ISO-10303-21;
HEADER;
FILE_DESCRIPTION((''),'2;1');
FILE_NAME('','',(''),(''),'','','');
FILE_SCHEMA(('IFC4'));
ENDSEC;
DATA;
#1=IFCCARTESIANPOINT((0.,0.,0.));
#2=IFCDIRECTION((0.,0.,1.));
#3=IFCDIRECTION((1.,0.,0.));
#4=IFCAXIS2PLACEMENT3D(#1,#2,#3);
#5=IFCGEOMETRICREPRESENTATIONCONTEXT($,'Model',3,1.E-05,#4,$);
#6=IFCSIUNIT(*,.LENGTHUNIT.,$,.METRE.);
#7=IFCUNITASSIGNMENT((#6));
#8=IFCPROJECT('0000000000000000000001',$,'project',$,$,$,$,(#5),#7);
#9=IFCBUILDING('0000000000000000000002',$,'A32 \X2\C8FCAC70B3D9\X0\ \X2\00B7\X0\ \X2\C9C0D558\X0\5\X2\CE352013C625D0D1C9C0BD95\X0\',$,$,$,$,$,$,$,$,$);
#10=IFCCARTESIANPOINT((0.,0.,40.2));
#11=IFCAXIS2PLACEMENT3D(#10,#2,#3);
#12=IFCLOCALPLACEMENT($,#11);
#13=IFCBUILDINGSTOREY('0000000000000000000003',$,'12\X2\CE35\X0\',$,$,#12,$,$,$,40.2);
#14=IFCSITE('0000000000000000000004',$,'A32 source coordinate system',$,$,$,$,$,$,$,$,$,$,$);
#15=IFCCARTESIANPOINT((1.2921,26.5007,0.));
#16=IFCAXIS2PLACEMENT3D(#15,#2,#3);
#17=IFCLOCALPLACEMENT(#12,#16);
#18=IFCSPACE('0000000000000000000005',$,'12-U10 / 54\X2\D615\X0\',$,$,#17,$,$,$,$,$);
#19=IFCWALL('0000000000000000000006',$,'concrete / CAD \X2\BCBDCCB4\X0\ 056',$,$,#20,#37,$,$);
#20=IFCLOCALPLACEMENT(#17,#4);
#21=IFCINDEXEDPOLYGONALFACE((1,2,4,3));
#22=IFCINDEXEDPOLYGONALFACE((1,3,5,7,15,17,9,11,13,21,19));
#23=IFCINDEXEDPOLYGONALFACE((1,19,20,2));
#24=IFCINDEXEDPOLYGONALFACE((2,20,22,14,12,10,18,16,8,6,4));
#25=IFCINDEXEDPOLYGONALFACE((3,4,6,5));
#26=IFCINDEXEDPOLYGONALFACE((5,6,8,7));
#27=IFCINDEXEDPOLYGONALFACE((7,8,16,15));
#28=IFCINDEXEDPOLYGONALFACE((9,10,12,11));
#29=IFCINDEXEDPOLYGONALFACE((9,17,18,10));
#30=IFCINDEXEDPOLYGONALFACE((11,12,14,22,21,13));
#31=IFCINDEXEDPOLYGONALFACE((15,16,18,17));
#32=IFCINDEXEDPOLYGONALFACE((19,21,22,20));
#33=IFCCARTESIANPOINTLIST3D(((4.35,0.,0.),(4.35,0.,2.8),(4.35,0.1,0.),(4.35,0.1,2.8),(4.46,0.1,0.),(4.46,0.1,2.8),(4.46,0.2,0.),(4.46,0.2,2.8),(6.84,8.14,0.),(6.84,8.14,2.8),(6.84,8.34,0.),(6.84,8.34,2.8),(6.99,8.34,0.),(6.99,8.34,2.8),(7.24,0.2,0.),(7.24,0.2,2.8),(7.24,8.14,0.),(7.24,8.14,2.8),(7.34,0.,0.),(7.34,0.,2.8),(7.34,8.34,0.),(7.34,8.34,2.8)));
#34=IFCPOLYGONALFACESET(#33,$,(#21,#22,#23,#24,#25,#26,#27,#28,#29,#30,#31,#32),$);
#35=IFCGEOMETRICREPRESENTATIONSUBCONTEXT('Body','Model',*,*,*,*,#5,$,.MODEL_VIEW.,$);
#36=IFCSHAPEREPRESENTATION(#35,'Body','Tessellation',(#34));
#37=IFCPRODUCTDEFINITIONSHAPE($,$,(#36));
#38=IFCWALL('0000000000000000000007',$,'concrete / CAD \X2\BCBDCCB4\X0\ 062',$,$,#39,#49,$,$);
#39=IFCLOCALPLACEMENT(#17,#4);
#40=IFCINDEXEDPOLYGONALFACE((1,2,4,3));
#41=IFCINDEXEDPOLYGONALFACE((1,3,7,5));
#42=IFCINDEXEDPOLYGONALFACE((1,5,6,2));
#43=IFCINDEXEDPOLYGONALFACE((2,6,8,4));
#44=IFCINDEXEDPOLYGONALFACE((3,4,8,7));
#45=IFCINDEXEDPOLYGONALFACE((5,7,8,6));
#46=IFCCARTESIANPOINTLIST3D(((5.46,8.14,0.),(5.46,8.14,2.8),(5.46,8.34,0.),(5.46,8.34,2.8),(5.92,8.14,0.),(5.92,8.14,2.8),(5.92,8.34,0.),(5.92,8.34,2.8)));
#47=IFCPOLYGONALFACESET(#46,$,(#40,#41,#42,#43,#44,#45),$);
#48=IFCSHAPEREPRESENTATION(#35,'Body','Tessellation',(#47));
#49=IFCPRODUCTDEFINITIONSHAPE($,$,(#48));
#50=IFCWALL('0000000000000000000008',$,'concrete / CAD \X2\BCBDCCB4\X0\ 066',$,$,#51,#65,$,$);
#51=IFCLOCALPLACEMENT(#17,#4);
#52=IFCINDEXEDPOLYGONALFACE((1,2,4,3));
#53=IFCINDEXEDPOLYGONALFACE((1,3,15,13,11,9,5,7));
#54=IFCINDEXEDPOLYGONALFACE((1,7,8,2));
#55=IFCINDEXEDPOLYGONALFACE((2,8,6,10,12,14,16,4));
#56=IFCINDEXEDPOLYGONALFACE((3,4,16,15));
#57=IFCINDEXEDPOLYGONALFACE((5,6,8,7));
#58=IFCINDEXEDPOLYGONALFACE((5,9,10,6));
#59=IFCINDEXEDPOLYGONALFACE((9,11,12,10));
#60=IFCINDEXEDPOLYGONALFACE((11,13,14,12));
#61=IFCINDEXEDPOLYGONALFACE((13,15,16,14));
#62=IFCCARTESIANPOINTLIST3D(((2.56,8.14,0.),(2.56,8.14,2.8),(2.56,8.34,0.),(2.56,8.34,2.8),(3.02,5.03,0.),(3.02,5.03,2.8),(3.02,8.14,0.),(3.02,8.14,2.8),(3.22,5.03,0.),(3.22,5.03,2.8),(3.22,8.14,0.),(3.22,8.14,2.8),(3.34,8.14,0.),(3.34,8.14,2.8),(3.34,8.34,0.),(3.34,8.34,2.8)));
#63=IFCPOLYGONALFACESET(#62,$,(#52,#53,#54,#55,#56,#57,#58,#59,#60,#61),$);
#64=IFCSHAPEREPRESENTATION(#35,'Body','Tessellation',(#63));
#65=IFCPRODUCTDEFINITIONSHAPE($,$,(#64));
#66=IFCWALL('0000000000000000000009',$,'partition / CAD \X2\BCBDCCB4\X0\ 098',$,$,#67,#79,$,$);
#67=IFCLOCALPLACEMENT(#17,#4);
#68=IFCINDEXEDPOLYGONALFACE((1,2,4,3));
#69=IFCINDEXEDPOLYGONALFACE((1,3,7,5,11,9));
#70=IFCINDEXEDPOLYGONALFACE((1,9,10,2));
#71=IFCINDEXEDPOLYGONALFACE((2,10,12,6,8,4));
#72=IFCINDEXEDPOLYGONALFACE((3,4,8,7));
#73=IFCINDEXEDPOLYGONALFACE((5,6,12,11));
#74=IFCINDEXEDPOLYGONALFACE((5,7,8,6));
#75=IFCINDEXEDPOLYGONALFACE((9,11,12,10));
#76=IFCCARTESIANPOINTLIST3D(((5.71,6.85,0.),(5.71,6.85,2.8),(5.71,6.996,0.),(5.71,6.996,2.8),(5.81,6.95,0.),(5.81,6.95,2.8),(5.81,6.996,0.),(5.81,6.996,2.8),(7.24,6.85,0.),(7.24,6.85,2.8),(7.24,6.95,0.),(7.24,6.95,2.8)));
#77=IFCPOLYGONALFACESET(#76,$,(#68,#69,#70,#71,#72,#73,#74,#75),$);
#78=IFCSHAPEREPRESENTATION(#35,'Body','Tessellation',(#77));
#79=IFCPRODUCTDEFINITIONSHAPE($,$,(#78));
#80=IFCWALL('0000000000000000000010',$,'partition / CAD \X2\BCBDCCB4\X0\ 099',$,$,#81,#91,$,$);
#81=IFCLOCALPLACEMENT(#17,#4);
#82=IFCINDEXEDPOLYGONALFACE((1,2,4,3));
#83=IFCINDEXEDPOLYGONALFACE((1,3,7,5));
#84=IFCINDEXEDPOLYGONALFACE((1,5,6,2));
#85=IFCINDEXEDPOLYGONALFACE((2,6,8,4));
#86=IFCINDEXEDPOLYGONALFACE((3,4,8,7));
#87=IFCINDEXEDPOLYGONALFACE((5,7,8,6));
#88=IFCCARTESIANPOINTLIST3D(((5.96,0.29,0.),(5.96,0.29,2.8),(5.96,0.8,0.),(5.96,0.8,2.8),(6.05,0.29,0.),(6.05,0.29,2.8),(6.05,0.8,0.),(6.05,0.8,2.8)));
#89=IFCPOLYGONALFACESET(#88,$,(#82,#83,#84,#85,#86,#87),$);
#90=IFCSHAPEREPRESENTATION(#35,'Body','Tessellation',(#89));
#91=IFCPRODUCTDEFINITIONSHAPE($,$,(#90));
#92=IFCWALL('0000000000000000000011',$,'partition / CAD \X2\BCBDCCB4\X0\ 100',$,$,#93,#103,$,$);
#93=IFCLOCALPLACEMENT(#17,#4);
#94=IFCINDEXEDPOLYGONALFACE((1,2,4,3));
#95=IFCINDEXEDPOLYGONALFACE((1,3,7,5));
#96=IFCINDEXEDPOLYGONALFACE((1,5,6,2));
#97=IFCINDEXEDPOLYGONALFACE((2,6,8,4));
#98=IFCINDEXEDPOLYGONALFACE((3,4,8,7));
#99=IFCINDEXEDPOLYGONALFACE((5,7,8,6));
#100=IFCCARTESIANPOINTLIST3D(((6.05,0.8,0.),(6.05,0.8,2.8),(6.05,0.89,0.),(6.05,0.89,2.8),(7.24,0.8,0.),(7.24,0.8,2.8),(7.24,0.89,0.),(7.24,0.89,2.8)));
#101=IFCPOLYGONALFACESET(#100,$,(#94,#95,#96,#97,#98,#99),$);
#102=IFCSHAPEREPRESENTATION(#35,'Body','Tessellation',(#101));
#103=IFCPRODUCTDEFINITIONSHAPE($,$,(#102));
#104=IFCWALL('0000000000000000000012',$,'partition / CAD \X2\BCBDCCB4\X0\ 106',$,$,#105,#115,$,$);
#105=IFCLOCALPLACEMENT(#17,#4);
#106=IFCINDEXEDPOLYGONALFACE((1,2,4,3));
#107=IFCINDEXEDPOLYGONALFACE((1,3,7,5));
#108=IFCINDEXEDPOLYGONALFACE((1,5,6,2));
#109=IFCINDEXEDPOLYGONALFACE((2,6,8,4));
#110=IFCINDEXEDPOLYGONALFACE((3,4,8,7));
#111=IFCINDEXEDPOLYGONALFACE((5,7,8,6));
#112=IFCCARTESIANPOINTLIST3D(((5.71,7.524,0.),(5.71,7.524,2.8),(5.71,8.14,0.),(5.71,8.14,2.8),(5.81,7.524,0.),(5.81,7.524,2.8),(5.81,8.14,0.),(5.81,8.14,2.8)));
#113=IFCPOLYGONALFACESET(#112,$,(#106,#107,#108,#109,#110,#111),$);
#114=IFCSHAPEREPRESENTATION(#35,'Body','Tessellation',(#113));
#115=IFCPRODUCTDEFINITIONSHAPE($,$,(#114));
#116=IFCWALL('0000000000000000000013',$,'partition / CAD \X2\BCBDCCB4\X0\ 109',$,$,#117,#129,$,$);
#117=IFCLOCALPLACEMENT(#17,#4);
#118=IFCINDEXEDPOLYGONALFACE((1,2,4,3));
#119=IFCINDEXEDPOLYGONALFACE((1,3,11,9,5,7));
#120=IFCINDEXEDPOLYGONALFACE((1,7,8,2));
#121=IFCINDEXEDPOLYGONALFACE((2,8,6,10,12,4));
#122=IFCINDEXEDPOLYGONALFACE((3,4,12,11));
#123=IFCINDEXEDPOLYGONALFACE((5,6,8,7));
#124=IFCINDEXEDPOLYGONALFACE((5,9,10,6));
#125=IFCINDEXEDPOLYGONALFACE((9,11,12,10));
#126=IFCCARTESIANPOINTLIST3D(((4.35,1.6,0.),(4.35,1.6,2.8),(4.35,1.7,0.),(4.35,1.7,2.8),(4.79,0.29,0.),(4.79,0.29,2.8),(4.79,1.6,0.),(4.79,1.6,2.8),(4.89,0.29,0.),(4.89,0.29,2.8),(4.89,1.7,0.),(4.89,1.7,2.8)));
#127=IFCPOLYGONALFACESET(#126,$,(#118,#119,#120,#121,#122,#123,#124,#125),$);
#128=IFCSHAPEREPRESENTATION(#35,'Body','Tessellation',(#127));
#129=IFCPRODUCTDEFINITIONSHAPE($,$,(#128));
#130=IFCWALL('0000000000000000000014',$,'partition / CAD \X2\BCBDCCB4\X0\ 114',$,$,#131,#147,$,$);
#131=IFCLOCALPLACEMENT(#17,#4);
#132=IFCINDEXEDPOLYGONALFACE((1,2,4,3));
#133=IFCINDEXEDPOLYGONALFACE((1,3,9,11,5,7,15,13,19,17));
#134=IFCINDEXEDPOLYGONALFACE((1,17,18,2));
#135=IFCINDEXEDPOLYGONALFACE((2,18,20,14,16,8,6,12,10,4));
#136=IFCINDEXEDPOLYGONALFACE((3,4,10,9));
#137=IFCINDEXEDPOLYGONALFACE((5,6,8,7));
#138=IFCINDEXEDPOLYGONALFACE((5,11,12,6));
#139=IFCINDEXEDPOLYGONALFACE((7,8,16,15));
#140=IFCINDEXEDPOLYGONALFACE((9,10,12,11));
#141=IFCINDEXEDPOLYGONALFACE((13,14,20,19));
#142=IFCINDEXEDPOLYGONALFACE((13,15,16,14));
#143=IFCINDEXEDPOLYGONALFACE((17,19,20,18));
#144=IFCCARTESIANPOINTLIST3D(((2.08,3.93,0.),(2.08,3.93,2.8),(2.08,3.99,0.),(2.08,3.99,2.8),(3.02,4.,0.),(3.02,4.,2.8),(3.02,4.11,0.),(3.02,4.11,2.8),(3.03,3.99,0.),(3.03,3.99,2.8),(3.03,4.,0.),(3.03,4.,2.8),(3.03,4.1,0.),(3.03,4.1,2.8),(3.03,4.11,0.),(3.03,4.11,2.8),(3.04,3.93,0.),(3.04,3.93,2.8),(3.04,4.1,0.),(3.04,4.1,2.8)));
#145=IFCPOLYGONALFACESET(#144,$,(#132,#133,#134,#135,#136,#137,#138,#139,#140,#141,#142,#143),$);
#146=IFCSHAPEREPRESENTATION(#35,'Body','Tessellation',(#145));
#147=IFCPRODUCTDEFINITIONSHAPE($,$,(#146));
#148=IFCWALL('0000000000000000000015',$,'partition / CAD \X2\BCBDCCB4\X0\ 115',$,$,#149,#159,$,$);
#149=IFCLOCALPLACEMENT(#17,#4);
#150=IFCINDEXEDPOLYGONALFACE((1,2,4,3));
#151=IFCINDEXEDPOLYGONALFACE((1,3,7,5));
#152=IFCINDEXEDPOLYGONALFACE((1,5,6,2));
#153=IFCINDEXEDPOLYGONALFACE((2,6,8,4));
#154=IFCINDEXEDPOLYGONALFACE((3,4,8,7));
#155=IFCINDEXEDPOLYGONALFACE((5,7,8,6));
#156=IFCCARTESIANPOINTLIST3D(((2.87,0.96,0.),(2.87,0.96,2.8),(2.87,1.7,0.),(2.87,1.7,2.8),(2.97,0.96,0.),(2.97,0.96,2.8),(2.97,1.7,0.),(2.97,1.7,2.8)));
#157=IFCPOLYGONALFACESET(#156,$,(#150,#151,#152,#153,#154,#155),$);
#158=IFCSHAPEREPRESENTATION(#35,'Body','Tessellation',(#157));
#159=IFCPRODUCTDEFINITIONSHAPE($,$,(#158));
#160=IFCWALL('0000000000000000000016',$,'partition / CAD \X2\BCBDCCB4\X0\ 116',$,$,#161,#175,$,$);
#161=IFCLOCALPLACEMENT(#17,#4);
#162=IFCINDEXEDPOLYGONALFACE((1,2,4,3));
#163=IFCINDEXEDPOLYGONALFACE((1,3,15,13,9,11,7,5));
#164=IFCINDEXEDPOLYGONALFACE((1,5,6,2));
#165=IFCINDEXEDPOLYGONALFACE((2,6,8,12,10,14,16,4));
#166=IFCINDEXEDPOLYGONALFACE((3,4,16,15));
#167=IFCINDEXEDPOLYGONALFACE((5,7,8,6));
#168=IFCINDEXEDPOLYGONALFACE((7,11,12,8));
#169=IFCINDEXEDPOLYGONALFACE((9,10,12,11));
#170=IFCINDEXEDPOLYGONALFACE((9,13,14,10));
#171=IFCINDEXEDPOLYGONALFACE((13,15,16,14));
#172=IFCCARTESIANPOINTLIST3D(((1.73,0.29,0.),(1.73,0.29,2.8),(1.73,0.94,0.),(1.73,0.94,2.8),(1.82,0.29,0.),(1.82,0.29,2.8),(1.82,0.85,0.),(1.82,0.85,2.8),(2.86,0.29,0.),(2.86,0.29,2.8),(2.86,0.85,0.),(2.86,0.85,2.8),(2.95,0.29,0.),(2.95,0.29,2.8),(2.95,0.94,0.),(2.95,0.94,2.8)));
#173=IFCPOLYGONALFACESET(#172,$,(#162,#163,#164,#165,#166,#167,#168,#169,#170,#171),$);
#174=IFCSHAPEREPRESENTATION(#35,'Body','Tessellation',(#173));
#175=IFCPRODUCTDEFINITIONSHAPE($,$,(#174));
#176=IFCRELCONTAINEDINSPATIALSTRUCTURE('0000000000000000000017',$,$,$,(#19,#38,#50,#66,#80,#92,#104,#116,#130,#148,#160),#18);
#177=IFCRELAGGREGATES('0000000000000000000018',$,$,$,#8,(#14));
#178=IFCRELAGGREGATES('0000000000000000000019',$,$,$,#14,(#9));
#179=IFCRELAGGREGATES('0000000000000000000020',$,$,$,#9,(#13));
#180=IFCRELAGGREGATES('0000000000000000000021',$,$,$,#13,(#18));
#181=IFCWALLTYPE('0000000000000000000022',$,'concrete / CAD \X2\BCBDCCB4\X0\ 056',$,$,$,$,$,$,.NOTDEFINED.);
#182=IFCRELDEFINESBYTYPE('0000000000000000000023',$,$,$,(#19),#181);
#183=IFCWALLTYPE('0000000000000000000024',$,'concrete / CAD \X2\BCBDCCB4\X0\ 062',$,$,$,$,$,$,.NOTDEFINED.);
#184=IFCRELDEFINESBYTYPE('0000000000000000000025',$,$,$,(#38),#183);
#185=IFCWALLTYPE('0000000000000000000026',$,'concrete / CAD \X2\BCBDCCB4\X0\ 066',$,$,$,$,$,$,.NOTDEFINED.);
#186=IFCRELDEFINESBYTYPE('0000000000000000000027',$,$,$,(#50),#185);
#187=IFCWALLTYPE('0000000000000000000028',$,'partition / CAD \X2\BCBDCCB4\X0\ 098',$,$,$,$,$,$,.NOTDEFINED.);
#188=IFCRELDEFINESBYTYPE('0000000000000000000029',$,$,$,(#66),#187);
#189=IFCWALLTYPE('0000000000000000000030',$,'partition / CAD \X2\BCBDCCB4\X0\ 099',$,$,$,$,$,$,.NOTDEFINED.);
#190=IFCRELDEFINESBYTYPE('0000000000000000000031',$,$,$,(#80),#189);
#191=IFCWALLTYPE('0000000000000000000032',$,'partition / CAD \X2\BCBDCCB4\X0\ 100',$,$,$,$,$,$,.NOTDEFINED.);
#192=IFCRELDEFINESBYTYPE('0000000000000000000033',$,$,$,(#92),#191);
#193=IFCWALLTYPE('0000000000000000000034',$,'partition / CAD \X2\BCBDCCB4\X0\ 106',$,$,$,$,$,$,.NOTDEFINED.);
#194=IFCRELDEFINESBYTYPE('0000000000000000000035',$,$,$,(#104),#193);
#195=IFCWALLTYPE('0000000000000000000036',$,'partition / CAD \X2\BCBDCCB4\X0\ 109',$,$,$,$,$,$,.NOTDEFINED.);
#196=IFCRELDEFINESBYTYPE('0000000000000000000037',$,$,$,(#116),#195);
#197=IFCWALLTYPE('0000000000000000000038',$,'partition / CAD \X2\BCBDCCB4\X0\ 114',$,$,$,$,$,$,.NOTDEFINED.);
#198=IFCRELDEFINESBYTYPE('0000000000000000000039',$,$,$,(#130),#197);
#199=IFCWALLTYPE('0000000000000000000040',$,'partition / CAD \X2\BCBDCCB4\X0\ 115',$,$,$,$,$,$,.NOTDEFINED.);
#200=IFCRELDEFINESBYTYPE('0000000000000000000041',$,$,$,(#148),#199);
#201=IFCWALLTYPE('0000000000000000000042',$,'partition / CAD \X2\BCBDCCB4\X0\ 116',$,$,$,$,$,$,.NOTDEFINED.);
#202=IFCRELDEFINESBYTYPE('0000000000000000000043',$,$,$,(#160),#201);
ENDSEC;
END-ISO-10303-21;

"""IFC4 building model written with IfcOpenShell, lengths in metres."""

from ifc_helpers import new_model, si_unit, frame, origin, origin_with_axes, place, context, subcontext, project, spatial, polyline, outline, extrude, source, transform, mapped, type_object, type_shapes, element, save


model = new_model("IFC4")

# Units and contexts
model_context = context("Model", 3, precision=1e-05, world=origin_with_axes())
body_context = subcontext(model_context, "Body", "Model", "MODEL_VIEW")
ifc_project = project(units=[si_unit("LENGTHUNIT", "METRE")], contexts=[model_context])

# Site, building, storey, space
site = spatial("IfcSite", under=ifc_project, Name="A32 source coordinate system")
building = spatial("IfcBuilding", under=site, Name="A32 주거동 · 지하5층–옥탑지붕")
storey_placement = place(None, frame((0.0, 0.0, 40.2), z_axis=(0.0, 0.0, 1.0), x_axis=(1.0, 0.0, 0.0)))
storey = spatial("IfcBuildingStorey", under=building, at=storey_placement, Name="12층", Elevation=40.2)
space_placement = place(storey_placement, frame((1.2921, 26.5007, 0.0), z_axis=(0.0, 0.0, 1.0), x_axis=(1.0, 0.0, 0.0)))
space = spatial("IfcSpace", under=storey, at=space_placement, Name="12-U10 / 54형")

# Walls
wall_type_1 = type_object("IfcWallType", Name="concrete / CAD 벽체 056", PredefinedType="NOTDEFINED")
shared_shape_1 = source(origin(), body_context, "Body", "SweptSolid", [
    extrude(outline(polyline([(7.24, 0.2), (7.24, 8.14), (6.84, 8.14), (6.84, 8.34), (6.99, 8.34), (6.99, 8.34), (7.34, 8.34), (7.34, 0.0), (4.35, 0.0), (4.35, 0.1), (4.46, 0.1), (4.46, 0.2), (7.24, 0.2)])), origin(), (0.0, 0.0, 1.0), 2.8),
])
type_shapes(wall_type_1, [shared_shape_1])
wall_1_placement = place(space_placement, origin_with_axes())
element("IfcWall", 1, at=wall_1_placement, inside=space, type_object=wall_type_1, Name="concrete / CAD 벽체 056", context=body_context, shape_type="MappedRepresentation", body=[
    mapped(shared_shape_1, transform((0.0, 0.0, 0.0), scale=1.0)),
])
wall_type_2 = type_object("IfcWallType", Name="concrete / CAD 벽체 062", PredefinedType="NOTDEFINED")
shared_shape_2 = source(origin(), body_context, "Body", "SweptSolid", [
    extrude(outline(polyline([(5.46, 8.14), (5.46, 8.34), (5.92, 8.34), (5.92, 8.14), (5.46, 8.14)])), origin(), (0.0, 0.0, 1.0), 2.8),
])
type_shapes(wall_type_2, [shared_shape_2])
wall_2_placement = place(space_placement, origin_with_axes())
element("IfcWall", 2, at=wall_2_placement, inside=space, type_object=wall_type_2, Name="concrete / CAD 벽체 062", context=body_context, shape_type="MappedRepresentation", body=[
    mapped(shared_shape_2, transform((0.0, 0.0, 0.0), scale=1.0)),
])
wall_type_3 = type_object("IfcWallType", Name="concrete / CAD 벽체 066", PredefinedType="NOTDEFINED")
shared_shape_3 = source(origin(), body_context, "Body", "SweptSolid", [
    extrude(outline(polyline([(3.22, 8.14), (3.22, 5.03), (3.02, 5.03), (3.02, 8.14), (2.56, 8.14), (2.56, 8.34), (3.34, 8.34), (3.34, 8.14), (3.22, 8.14)])), origin(), (0.0, 0.0, 1.0), 2.8),
])
type_shapes(wall_type_3, [shared_shape_3])
wall_3_placement = place(space_placement, origin_with_axes())
element("IfcWall", 3, at=wall_3_placement, inside=space, type_object=wall_type_3, Name="concrete / CAD 벽체 066", context=body_context, shape_type="MappedRepresentation", body=[
    mapped(shared_shape_3, transform((0.0, 0.0, 0.0), scale=1.0)),
])
wall_type_4 = type_object("IfcWallType", Name="partition / CAD 벽체 098", PredefinedType="NOTDEFINED")
shared_shape_4 = source(origin(), body_context, "Body", "SweptSolid", [
    extrude(outline(polyline([(5.71, 6.996), (5.81, 6.996), (5.81, 6.95), (7.24, 6.95), (7.24, 6.85), (5.71, 6.85), (5.71, 6.996)])), origin(), (0.0, 0.0, 1.0), 2.8),
])
type_shapes(wall_type_4, [shared_shape_4])
wall_4_placement = place(space_placement, origin_with_axes())
element("IfcWall", 4, at=wall_4_placement, inside=space, type_object=wall_type_4, Name="partition / CAD 벽체 098", context=body_context, shape_type="MappedRepresentation", body=[
    mapped(shared_shape_4, transform((0.0, 0.0, 0.0), scale=1.0)),
])
wall_type_5 = type_object("IfcWallType", Name="partition / CAD 벽체 099", PredefinedType="NOTDEFINED")
shared_shape_5 = source(origin(), body_context, "Body", "SweptSolid", [
    extrude(outline(polyline([(6.05, 0.8), (6.05, 0.29), (5.96, 0.29), (5.96, 0.8), (6.05, 0.8)])), origin(), (0.0, 0.0, 1.0), 2.8),
])
type_shapes(wall_type_5, [shared_shape_5])
wall_5_placement = place(space_placement, origin_with_axes())
element("IfcWall", 5, at=wall_5_placement, inside=space, type_object=wall_type_5, Name="partition / CAD 벽체 099", context=body_context, shape_type="MappedRepresentation", body=[
    mapped(shared_shape_5, transform((0.0, 0.0, 0.0), scale=1.0)),
])
wall_type_6 = type_object("IfcWallType", Name="partition / CAD 벽체 100", PredefinedType="NOTDEFINED")
shared_shape_6 = source(origin(), body_context, "Body", "SweptSolid", [
    extrude(outline(polyline([(7.24, 0.8), (6.05, 0.8), (6.05, 0.89), (7.24, 0.89), (7.24, 0.8)])), origin(), (0.0, 0.0, 1.0), 2.8),
])
type_shapes(wall_type_6, [shared_shape_6])
wall_6_placement = place(space_placement, origin_with_axes())
element("IfcWall", 6, at=wall_6_placement, inside=space, type_object=wall_type_6, Name="partition / CAD 벽체 100", context=body_context, shape_type="MappedRepresentation", body=[
    mapped(shared_shape_6, transform((0.0, 0.0, 0.0), scale=1.0)),
])
wall_type_7 = type_object("IfcWallType", Name="partition / CAD 벽체 106", PredefinedType="NOTDEFINED")
shared_shape_7 = source(origin(), body_context, "Body", "SweptSolid", [
    extrude(outline(polyline([(5.71, 8.14), (5.81, 8.14), (5.81, 7.524), (5.71, 7.524), (5.71, 8.14)])), origin(), (0.0, 0.0, 1.0), 2.8),
])
type_shapes(wall_type_7, [shared_shape_7])
wall_7_placement = place(space_placement, origin_with_axes())
element("IfcWall", 7, at=wall_7_placement, inside=space, type_object=wall_type_7, Name="partition / CAD 벽체 106", context=body_context, shape_type="MappedRepresentation", body=[
    mapped(shared_shape_7, transform((0.0, 0.0, 0.0), scale=1.0)),
])
wall_type_8 = type_object("IfcWallType", Name="partition / CAD 벽체 109", PredefinedType="NOTDEFINED")
shared_shape_8 = source(origin(), body_context, "Body", "SweptSolid", [
    extrude(outline(polyline([(4.79, 1.6), (4.35, 1.6), (4.35, 1.7), (4.89, 1.7), (4.89, 0.29), (4.79, 0.29), (4.79, 1.6)])), origin(), (0.0, 0.0, 1.0), 2.8),
])
type_shapes(wall_type_8, [shared_shape_8])
wall_8_placement = place(space_placement, origin_with_axes())
element("IfcWall", 8, at=wall_8_placement, inside=space, type_object=wall_type_8, Name="partition / CAD 벽체 109", context=body_context, shape_type="MappedRepresentation", body=[
    mapped(shared_shape_8, transform((0.0, 0.0, 0.0), scale=1.0)),
])
wall_type_9 = type_object("IfcWallType", Name="partition / CAD 벽체 114", PredefinedType="NOTDEFINED")
shared_shape_9 = source(origin(), body_context, "Body", "SweptSolid", [
    extrude(outline(polyline([(2.08, 3.99), (3.03, 3.99), (3.03, 4.0), (3.02, 4.0), (3.02, 4.11), (3.03, 4.11), (3.03, 4.1), (3.04, 4.1), (3.04, 3.93), (2.08, 3.93), (2.08, 3.99)])), origin(), (0.0, 0.0, 1.0), 2.8),
])
type_shapes(wall_type_9, [shared_shape_9])
wall_9_placement = place(space_placement, origin_with_axes())
element("IfcWall", 9, at=wall_9_placement, inside=space, type_object=wall_type_9, Name="partition / CAD 벽체 114", context=body_context, shape_type="MappedRepresentation", body=[
    mapped(shared_shape_9, transform((0.0, 0.0, 0.0), scale=1.0)),
])
wall_type_10 = type_object("IfcWallType", Name="partition / CAD 벽체 115", PredefinedType="NOTDEFINED")
shared_shape_10 = source(origin(), body_context, "Body", "SweptSolid", [
    extrude(outline(polyline([(2.87, 1.7), (2.97, 1.7), (2.97, 0.96), (2.87, 0.96), (2.87, 1.7)])), origin(), (0.0, 0.0, 1.0), 2.8),
])
type_shapes(wall_type_10, [shared_shape_10])
wall_10_placement = place(space_placement, origin_with_axes())
element("IfcWall", 10, at=wall_10_placement, inside=space, type_object=wall_type_10, Name="partition / CAD 벽체 115", context=body_context, shape_type="MappedRepresentation", body=[
    mapped(shared_shape_10, transform((0.0, 0.0, 0.0), scale=1.0)),
])
wall_type_11 = type_object("IfcWallType", Name="partition / CAD 벽체 116", PredefinedType="NOTDEFINED")
shared_shape_11 = source(origin(), body_context, "Body", "SweptSolid", [
    extrude(outline(polyline([(2.95, 0.29), (2.86, 0.29), (2.86, 0.85), (1.82, 0.85), (1.82, 0.29), (1.73, 0.29), (1.73, 0.94), (2.95, 0.94), (2.95, 0.29)])), origin(), (0.0, 0.0, 1.0), 2.8),
])
type_shapes(wall_type_11, [shared_shape_11])
wall_11_placement = place(space_placement, origin_with_axes())
element("IfcWall", 11, at=wall_11_placement, inside=space, type_object=wall_type_11, Name="partition / CAD 벽체 116", context=body_context, shape_type="MappedRepresentation", body=[
    mapped(shared_shape_11, transform((0.0, 0.0, 0.0), scale=1.0)),
])

save(model, "model.ifc")
